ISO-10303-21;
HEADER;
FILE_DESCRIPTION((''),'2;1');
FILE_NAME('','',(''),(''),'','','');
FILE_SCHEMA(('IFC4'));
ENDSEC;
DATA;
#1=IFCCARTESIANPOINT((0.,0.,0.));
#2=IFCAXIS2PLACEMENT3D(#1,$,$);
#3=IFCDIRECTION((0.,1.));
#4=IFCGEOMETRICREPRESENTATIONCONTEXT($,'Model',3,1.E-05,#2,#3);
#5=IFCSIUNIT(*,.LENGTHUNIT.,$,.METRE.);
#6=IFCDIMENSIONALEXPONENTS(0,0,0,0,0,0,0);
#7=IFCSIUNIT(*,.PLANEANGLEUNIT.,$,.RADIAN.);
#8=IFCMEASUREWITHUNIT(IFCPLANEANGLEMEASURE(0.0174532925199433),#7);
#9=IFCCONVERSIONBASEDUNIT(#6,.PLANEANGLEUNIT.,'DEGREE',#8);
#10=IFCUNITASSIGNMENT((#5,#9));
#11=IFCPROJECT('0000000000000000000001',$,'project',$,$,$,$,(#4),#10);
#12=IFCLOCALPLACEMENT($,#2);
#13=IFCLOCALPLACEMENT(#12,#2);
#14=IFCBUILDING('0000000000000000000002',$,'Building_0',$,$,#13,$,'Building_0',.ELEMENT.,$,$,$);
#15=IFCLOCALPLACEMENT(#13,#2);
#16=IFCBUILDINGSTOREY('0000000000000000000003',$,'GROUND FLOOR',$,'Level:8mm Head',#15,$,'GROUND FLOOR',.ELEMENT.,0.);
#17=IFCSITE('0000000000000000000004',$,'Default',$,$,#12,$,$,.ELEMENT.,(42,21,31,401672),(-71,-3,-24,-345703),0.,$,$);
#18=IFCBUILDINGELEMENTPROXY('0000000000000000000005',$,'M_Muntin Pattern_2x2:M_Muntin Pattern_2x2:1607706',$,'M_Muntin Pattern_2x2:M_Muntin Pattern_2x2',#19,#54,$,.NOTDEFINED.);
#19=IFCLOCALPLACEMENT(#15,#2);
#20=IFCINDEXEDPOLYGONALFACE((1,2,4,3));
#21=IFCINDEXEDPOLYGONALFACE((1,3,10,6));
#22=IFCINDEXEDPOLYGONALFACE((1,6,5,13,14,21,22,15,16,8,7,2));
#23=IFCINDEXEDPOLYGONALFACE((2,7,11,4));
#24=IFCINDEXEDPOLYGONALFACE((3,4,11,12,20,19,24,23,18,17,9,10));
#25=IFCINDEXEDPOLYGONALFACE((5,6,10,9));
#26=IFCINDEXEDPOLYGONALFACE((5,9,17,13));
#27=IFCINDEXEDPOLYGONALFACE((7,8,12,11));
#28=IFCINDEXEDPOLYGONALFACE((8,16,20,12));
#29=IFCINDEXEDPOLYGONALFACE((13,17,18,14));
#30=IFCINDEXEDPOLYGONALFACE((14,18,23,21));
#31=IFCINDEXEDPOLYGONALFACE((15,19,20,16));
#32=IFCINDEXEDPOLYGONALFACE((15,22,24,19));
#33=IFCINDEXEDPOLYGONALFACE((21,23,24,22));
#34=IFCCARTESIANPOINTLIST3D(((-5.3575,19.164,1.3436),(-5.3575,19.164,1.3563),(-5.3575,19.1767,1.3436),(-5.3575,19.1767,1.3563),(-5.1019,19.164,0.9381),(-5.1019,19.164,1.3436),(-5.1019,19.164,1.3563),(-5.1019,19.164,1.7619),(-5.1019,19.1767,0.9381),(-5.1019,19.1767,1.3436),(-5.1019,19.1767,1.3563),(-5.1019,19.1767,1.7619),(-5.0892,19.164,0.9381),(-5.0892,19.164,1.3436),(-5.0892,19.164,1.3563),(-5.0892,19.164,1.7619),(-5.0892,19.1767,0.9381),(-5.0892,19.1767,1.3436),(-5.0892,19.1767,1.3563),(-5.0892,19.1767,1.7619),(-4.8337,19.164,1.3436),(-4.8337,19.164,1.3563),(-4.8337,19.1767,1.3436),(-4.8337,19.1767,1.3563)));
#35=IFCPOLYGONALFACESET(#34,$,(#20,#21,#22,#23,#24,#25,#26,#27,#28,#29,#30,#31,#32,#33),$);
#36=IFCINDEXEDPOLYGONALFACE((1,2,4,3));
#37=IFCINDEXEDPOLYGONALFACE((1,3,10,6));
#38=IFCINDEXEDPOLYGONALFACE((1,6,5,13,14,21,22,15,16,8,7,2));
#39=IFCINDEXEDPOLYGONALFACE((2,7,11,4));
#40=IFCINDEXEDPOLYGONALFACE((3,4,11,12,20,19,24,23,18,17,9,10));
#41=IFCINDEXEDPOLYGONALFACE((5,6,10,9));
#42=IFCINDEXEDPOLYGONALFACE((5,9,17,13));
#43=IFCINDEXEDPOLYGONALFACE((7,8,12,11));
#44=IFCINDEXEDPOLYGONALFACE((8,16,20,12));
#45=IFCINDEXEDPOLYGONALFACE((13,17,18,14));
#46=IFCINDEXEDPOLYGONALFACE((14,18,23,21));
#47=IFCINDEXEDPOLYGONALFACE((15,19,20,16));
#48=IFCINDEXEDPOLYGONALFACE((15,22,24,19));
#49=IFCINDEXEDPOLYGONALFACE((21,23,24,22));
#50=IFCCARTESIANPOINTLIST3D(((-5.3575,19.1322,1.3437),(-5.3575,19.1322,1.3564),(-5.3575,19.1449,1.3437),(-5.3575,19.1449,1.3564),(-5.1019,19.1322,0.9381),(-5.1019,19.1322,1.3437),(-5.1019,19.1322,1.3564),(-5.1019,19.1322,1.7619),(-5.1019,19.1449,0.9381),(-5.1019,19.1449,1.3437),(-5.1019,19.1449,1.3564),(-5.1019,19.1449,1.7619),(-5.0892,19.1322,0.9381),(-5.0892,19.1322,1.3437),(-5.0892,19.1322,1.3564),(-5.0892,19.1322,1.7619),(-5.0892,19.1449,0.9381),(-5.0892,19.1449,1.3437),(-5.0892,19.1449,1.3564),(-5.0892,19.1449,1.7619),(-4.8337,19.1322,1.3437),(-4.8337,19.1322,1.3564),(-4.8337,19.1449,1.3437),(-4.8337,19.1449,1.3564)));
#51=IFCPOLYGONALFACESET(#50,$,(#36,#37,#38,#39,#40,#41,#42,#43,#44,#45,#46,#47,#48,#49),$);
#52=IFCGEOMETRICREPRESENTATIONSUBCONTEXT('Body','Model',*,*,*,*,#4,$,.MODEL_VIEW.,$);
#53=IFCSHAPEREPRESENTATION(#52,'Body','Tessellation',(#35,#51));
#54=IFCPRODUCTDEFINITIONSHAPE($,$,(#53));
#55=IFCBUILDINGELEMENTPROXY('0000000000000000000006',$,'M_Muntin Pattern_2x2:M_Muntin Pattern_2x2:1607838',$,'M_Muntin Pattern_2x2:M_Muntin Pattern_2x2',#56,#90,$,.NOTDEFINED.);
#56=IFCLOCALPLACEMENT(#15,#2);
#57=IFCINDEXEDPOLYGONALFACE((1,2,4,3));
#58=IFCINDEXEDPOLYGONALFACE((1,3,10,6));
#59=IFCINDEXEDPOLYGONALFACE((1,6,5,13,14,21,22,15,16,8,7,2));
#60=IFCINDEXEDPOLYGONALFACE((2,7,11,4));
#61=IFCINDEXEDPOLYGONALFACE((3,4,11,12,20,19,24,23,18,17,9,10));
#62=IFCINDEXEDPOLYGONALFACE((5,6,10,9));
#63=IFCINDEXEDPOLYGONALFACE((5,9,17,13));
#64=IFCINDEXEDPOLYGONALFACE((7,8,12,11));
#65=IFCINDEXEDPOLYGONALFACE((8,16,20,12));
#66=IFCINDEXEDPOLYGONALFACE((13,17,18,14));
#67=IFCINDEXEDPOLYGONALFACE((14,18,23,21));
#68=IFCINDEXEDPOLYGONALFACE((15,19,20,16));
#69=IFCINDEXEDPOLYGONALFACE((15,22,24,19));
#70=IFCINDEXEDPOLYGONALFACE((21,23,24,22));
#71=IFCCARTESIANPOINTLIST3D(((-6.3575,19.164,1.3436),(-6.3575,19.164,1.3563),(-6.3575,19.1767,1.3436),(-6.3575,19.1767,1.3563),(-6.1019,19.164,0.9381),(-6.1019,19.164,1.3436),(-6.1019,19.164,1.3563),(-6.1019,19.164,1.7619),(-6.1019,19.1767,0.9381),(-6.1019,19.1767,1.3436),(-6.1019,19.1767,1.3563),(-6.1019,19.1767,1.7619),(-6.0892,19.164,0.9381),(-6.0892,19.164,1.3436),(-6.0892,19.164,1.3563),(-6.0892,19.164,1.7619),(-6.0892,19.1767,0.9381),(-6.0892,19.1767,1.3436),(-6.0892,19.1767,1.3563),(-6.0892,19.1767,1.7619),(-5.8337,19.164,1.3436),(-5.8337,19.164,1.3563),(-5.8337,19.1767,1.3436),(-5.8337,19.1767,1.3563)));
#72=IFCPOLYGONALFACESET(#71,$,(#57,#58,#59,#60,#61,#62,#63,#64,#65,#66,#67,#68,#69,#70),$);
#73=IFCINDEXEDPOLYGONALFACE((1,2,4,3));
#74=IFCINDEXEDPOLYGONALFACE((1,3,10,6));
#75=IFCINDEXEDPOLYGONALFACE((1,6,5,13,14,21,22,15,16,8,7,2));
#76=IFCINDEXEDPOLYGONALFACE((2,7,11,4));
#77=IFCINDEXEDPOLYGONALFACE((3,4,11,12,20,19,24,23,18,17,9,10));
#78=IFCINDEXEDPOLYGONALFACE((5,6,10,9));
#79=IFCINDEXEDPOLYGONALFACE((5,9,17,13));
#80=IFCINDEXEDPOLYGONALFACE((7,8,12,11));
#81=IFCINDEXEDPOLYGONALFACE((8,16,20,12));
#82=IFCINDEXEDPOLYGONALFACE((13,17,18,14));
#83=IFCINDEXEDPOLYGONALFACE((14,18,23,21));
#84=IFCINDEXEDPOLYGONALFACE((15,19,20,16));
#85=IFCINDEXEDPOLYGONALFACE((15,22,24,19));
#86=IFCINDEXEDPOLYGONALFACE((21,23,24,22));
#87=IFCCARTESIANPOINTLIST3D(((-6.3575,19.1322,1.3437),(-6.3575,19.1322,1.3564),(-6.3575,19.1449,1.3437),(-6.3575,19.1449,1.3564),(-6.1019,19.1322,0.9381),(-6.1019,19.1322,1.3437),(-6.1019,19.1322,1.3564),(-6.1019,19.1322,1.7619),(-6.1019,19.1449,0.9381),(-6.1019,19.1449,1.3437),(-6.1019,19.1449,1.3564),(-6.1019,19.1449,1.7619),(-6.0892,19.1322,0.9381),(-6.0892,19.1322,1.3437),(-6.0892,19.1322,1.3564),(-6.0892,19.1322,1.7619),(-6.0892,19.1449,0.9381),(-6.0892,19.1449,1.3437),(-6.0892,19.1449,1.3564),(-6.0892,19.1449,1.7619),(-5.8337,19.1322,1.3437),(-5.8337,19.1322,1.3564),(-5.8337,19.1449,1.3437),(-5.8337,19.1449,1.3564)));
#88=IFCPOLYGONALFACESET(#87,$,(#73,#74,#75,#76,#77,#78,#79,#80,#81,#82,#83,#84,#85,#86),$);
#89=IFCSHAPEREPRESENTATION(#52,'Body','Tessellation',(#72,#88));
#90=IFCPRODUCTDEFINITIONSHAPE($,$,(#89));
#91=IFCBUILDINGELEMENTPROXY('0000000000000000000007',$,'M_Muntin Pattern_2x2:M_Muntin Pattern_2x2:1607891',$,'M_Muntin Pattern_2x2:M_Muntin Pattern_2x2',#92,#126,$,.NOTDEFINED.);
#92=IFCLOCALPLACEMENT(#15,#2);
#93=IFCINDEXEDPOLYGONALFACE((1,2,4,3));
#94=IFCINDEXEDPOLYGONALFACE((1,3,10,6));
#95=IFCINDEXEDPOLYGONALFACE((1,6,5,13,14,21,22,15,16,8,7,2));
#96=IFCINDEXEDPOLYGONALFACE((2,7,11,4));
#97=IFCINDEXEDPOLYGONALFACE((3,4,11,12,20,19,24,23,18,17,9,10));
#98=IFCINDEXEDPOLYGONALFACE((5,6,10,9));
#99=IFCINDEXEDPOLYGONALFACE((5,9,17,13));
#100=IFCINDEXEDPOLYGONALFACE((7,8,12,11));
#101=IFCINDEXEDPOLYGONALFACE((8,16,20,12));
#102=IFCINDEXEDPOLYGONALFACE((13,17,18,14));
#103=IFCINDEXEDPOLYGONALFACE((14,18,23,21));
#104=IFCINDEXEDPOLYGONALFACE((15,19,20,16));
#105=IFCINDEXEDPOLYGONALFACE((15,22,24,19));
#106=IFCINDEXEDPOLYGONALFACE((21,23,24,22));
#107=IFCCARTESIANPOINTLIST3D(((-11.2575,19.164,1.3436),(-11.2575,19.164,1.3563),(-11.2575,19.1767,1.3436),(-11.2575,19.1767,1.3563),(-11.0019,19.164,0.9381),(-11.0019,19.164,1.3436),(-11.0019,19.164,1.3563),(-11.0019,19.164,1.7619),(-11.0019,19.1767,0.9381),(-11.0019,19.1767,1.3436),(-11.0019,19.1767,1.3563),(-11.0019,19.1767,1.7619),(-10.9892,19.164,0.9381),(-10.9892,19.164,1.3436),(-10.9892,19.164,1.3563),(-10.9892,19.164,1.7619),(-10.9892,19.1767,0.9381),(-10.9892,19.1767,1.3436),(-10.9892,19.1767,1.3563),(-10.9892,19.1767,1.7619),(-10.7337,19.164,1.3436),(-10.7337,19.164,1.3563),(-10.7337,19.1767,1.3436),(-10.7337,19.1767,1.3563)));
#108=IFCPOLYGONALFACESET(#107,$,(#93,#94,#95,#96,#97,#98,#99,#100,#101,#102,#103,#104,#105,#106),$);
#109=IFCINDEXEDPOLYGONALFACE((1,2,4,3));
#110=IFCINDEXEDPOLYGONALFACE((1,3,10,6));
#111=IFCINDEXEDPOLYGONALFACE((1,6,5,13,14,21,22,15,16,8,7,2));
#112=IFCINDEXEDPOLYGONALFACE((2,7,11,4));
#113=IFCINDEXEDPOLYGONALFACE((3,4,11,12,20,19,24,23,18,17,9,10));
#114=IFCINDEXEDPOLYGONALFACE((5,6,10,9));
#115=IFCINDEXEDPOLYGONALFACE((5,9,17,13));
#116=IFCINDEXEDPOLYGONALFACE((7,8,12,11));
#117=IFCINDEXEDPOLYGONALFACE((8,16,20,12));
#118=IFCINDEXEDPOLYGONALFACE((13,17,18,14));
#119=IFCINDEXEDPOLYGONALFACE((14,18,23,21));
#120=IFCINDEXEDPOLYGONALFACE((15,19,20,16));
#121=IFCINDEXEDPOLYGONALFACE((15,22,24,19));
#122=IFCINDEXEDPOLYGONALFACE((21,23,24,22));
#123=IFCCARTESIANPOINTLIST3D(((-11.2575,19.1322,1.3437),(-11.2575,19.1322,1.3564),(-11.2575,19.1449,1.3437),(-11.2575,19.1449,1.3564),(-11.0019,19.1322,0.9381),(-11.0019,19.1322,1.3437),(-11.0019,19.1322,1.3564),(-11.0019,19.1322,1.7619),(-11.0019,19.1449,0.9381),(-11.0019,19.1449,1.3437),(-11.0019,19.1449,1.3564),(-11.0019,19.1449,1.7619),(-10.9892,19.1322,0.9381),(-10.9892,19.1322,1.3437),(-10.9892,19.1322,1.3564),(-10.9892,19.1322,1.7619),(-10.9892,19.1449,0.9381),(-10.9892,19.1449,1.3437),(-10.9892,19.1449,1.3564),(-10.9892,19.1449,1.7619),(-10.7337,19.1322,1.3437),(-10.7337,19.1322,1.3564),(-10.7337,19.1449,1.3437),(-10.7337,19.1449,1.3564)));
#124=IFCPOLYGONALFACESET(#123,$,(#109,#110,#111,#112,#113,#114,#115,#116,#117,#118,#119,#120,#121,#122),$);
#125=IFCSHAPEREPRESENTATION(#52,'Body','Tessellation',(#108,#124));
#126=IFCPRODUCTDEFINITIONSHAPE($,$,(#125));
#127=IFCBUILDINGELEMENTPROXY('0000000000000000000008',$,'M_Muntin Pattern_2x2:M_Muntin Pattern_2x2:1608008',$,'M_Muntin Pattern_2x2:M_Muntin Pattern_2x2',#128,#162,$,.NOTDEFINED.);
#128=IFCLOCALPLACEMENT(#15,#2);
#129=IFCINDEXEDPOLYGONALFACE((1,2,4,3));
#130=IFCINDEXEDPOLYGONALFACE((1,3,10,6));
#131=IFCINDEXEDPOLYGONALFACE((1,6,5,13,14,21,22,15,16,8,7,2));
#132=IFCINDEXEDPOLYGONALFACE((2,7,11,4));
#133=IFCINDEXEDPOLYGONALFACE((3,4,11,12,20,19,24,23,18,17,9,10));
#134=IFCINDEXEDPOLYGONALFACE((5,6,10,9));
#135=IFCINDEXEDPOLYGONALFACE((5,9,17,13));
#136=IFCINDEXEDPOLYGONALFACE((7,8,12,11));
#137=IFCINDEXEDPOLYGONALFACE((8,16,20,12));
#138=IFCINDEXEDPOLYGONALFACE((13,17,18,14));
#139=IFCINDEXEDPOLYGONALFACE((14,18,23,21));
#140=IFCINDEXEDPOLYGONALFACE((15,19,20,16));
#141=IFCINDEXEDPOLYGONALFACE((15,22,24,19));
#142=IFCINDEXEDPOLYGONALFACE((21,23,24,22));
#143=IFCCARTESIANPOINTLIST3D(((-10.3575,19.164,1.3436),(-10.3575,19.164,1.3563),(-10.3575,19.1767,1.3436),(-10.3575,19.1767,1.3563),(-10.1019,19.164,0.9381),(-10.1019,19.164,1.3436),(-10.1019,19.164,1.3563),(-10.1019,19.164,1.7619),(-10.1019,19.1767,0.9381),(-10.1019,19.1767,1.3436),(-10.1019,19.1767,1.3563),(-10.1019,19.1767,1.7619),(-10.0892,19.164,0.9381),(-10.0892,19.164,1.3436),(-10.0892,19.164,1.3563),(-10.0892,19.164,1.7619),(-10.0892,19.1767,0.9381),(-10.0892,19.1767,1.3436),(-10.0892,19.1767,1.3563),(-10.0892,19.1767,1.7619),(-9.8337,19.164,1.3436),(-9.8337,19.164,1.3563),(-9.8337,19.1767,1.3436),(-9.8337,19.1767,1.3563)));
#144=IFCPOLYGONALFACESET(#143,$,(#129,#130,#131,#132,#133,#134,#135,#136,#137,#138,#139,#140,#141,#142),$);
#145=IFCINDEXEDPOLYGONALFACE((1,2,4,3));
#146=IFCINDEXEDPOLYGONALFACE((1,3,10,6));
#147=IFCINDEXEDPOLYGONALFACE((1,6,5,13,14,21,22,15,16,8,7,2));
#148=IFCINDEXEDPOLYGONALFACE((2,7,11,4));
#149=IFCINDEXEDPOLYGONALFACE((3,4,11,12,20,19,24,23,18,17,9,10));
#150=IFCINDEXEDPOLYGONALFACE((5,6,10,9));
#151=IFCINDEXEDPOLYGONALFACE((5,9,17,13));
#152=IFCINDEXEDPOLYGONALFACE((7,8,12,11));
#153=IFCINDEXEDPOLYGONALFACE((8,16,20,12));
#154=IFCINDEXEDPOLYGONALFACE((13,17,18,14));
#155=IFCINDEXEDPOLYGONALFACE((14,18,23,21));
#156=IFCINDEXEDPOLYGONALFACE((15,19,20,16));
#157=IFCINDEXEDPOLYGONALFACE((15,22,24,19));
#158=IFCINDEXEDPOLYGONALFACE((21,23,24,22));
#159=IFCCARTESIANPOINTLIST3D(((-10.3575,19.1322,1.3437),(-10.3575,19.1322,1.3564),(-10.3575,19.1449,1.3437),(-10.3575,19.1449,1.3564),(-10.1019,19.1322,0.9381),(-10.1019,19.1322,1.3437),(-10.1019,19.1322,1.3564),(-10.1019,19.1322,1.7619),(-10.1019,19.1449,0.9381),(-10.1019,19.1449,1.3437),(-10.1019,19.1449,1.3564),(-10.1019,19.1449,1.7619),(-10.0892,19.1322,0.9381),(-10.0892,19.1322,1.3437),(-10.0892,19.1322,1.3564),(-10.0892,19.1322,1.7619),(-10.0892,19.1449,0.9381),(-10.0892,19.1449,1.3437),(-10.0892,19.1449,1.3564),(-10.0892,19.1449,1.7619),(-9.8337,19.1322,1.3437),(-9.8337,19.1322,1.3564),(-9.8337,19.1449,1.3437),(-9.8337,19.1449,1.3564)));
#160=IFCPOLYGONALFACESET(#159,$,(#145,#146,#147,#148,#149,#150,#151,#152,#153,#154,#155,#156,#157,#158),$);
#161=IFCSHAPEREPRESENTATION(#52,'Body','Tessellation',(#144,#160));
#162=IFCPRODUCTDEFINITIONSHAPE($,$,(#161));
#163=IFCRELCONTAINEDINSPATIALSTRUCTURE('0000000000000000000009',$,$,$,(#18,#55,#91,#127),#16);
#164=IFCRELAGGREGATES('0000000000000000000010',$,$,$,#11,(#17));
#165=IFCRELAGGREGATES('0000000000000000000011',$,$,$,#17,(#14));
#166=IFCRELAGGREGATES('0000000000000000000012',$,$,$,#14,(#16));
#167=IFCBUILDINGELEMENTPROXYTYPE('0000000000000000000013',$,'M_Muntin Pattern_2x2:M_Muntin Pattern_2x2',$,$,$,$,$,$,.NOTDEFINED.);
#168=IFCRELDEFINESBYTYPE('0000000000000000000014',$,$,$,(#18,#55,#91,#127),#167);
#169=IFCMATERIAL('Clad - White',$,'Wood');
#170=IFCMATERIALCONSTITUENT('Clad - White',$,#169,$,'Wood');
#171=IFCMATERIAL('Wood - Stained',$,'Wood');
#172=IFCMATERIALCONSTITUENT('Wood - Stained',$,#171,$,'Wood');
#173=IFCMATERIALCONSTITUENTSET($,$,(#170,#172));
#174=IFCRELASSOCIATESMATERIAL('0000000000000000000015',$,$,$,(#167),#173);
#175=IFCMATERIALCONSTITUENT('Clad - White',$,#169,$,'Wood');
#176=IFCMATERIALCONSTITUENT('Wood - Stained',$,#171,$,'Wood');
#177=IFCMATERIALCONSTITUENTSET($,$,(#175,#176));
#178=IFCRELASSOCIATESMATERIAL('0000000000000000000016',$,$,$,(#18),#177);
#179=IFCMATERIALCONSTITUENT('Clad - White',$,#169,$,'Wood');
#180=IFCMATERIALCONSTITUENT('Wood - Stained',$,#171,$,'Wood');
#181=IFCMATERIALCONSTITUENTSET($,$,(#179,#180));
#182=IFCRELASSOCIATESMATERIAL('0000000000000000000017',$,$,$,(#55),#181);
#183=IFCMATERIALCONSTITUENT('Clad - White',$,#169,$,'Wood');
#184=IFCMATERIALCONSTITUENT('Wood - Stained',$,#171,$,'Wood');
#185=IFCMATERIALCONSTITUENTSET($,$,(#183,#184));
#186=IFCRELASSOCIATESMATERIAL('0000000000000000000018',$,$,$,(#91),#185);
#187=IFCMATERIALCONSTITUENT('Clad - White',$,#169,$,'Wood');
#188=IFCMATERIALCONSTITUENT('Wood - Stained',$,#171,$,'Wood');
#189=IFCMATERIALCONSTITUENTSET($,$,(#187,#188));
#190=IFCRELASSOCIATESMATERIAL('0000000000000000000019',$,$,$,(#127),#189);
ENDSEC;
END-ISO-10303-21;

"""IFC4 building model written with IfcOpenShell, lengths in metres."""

from ifc_helpers import new_model, entity, si_unit, converted_unit, direction, frame, origin, place, context, subcontext, project, spatial, indexed_curve, outline, extrude, source, transform, mapped, material, constituent, constituent_set, type_object, type_shapes, element, save


model = new_model("IFC4")

# Units and contexts
model_context = context("Model", 3, precision=1e-05, world=origin(), true_north=direction((0.0, 1.0)))
body_context = subcontext(model_context, "Body", "Model", "MODEL_VIEW")
ifc_project = project(units=[si_unit("LENGTHUNIT", "METRE"), converted_unit("PLANEANGLEUNIT", "DEGREE", entity("IfcPlaneAngleMeasure", 0.0174532925199433), si_unit("PLANEANGLEUNIT", "RADIAN"), dimensions=[0, 0, 0, 0, 0, 0, 0])], contexts=[model_context])

# Site, building, storey
site_placement = place(None, origin())
site = spatial("IfcSite", under=ifc_project, at=site_placement, Name="Default", CompositionType="ELEMENT", RefLatitude=(42, 21, 31, 401672), RefLongitude=(-71, -3, -24, -345703), RefElevation=0.0)
building_placement = place(site_placement, origin())
building = spatial("IfcBuilding", under=site, at=building_placement, Name="Building_0", LongName="Building_0", CompositionType="ELEMENT")
storey_placement = place(building_placement, origin())
storey = spatial("IfcBuildingStorey", under=building, at=storey_placement, Name="GROUND FLOOR", ObjectType="Level:8mm Head", LongName="GROUND FLOOR", CompositionType="ELEMENT", Elevation=0.0)

# Shared definitions
ifc_material_1 = material(Name="Clad - White", Category="Wood")

# Building element proxies
ifc_material_2 = material(Name="Wood - Stained", Category="Wood")
ifc_constituent_1 = constituent(ifc_material_1, Name="Clad - White", Category="Wood")
ifc_constituent_2 = constituent(ifc_material_2, Name="Wood - Stained", Category="Wood")
ifc_constituent_set_1 = constituent_set(constituents=[ifc_constituent_1, ifc_constituent_2])
ifc_constituent_3 = constituent(ifc_material_1, Name="Clad - White", Category="Wood")
ifc_constituent_4 = constituent(ifc_material_2, Name="Wood - Stained", Category="Wood")
ifc_constituent_set_2 = constituent_set(constituents=[ifc_constituent_3, ifc_constituent_4])
building_element_proxy_type_1 = type_object("IfcBuildingElementProxyType", Name="M_Muntin Pattern_2x2:M_Muntin Pattern_2x2", PredefinedType="NOTDEFINED", material=ifc_constituent_set_2)
shared_shape_1 = source(origin(), body_context, "Body", "SweptSolid", [
    extrude(outline(indexed_curve([(0.0064, -0.0064), (0.4119, -0.0064), (0.4119, 0.0063), (0.0064, 0.0063), (0.0064, 0.2619), (-0.0063, 0.2619), (-0.0063, 0.0063), (-0.4119, 0.0063), (-0.4119, -0.0064), (-0.0063, -0.0064), (-0.0063, -0.2619), (0.0064, -0.2619), (0.0064, -0.0064)], self_intersect=False)), frame((0.0, -0.0222, 0.4119), z_axis=(0.0, 1.0, 0.0), x_axis=(0.0, 0.0, 1.0)), (0.0, 0.0, 1.0), 0.0127),
    extrude(outline(indexed_curve([(0.0064, -0.0064), (0.4119, -0.0064), (0.4119, 0.0063), (0.0064, 0.0063), (0.0064, 0.2619), (-0.0063, 0.2619), (-0.0063, 0.0063), (-0.4119, 0.0063), (-0.4119, -0.0064), (-0.0063, -0.0064), (-0.0063, -0.2619), (0.0064, -0.2619), (0.0064, -0.0064)], self_intersect=False)), frame((0.0, 0.0095, 0.4119), z_axis=(0.0, 1.0, 0.0), x_axis=(0.0, 0.0, 1.0)), (0.0, 0.0, 1.0), 0.0127),
])
type_shapes(building_element_proxy_type_1, [shared_shape_1])
proxy_1_placement = place(storey_placement, frame((-5.0956, 19.1545, 0.9381), z_axis=(0.0, 0.0, 1.0), x_axis=(-1.0, 0.0, 0.0)))
element("IfcBuildingElementProxy", 1, at=proxy_1_placement, inside=storey, type_object=building_element_proxy_type_1, material=ifc_constituent_set_1, Name="M_Muntin Pattern_2x2:M_Muntin Pattern_2x2:1607706", ObjectType="M_Muntin Pattern_2x2:M_Muntin Pattern_2x2", PredefinedType="NOTDEFINED", context=body_context, shape_type="MappedRepresentation", body=[
    mapped(shared_shape_1, transform((0.0, 0.0, 0.0), scale=1.0)),
])
ifc_constituent_5 = constituent(ifc_material_1, Name="Clad - White", Category="Wood")
ifc_constituent_6 = constituent(ifc_material_2, Name="Wood - Stained", Category="Wood")
ifc_constituent_set_3 = constituent_set(constituents=[ifc_constituent_5, ifc_constituent_6])
proxy_2_placement = place(storey_placement, frame((-6.0956, 19.1545, 0.9381), z_axis=(0.0, 0.0, 1.0), x_axis=(-1.0, 0.0, 0.0)))
element("IfcBuildingElementProxy", 2, at=proxy_2_placement, inside=storey, type_object=building_element_proxy_type_1, material=ifc_constituent_set_3, Name="M_Muntin Pattern_2x2:M_Muntin Pattern_2x2:1607838", ObjectType="M_Muntin Pattern_2x2:M_Muntin Pattern_2x2", PredefinedType="NOTDEFINED", context=body_context, shape_type="MappedRepresentation", body=[
    mapped(shared_shape_1, transform((0.0, 0.0, 0.0), scale=1.0)),
])
ifc_constituent_7 = constituent(ifc_material_1, Name="Clad - White", Category="Wood")
ifc_constituent_8 = constituent(ifc_material_2, Name="Wood - Stained", Category="Wood")
ifc_constituent_set_4 = constituent_set(constituents=[ifc_constituent_7, ifc_constituent_8])
proxy_3_placement = place(storey_placement, frame((-10.9956, 19.1545, 0.9381), z_axis=(0.0, 0.0, 1.0), x_axis=(-1.0, 0.0, 0.0)))
element("IfcBuildingElementProxy", 3, at=proxy_3_placement, inside=storey, type_object=building_element_proxy_type_1, material=ifc_constituent_set_4, Name="M_Muntin Pattern_2x2:M_Muntin Pattern_2x2:1607891", ObjectType="M_Muntin Pattern_2x2:M_Muntin Pattern_2x2", PredefinedType="NOTDEFINED", context=body_context, shape_type="MappedRepresentation", body=[
    mapped(shared_shape_1, transform((0.0, 0.0, 0.0), scale=1.0)),
])
ifc_constituent_9 = constituent(ifc_material_1, Name="Clad - White", Category="Wood")
ifc_constituent_10 = constituent(ifc_material_2, Name="Wood - Stained", Category="Wood")
ifc_constituent_set_5 = constituent_set(constituents=[ifc_constituent_9, ifc_constituent_10])
proxy_4_placement = place(storey_placement, frame((-10.0956, 19.1545, 0.9381), z_axis=(0.0, 0.0, 1.0), x_axis=(-1.0, 0.0, 0.0)))
element("IfcBuildingElementProxy", 4, at=proxy_4_placement, inside=storey, type_object=building_element_proxy_type_1, material=ifc_constituent_set_5, Name="M_Muntin Pattern_2x2:M_Muntin Pattern_2x2:1608008", ObjectType="M_Muntin Pattern_2x2:M_Muntin Pattern_2x2", PredefinedType="NOTDEFINED", context=body_context, shape_type="MappedRepresentation", body=[
    mapped(shared_shape_1, transform((0.0, 0.0, 0.0), scale=1.0)),
])

save(model, "model.ifc")
